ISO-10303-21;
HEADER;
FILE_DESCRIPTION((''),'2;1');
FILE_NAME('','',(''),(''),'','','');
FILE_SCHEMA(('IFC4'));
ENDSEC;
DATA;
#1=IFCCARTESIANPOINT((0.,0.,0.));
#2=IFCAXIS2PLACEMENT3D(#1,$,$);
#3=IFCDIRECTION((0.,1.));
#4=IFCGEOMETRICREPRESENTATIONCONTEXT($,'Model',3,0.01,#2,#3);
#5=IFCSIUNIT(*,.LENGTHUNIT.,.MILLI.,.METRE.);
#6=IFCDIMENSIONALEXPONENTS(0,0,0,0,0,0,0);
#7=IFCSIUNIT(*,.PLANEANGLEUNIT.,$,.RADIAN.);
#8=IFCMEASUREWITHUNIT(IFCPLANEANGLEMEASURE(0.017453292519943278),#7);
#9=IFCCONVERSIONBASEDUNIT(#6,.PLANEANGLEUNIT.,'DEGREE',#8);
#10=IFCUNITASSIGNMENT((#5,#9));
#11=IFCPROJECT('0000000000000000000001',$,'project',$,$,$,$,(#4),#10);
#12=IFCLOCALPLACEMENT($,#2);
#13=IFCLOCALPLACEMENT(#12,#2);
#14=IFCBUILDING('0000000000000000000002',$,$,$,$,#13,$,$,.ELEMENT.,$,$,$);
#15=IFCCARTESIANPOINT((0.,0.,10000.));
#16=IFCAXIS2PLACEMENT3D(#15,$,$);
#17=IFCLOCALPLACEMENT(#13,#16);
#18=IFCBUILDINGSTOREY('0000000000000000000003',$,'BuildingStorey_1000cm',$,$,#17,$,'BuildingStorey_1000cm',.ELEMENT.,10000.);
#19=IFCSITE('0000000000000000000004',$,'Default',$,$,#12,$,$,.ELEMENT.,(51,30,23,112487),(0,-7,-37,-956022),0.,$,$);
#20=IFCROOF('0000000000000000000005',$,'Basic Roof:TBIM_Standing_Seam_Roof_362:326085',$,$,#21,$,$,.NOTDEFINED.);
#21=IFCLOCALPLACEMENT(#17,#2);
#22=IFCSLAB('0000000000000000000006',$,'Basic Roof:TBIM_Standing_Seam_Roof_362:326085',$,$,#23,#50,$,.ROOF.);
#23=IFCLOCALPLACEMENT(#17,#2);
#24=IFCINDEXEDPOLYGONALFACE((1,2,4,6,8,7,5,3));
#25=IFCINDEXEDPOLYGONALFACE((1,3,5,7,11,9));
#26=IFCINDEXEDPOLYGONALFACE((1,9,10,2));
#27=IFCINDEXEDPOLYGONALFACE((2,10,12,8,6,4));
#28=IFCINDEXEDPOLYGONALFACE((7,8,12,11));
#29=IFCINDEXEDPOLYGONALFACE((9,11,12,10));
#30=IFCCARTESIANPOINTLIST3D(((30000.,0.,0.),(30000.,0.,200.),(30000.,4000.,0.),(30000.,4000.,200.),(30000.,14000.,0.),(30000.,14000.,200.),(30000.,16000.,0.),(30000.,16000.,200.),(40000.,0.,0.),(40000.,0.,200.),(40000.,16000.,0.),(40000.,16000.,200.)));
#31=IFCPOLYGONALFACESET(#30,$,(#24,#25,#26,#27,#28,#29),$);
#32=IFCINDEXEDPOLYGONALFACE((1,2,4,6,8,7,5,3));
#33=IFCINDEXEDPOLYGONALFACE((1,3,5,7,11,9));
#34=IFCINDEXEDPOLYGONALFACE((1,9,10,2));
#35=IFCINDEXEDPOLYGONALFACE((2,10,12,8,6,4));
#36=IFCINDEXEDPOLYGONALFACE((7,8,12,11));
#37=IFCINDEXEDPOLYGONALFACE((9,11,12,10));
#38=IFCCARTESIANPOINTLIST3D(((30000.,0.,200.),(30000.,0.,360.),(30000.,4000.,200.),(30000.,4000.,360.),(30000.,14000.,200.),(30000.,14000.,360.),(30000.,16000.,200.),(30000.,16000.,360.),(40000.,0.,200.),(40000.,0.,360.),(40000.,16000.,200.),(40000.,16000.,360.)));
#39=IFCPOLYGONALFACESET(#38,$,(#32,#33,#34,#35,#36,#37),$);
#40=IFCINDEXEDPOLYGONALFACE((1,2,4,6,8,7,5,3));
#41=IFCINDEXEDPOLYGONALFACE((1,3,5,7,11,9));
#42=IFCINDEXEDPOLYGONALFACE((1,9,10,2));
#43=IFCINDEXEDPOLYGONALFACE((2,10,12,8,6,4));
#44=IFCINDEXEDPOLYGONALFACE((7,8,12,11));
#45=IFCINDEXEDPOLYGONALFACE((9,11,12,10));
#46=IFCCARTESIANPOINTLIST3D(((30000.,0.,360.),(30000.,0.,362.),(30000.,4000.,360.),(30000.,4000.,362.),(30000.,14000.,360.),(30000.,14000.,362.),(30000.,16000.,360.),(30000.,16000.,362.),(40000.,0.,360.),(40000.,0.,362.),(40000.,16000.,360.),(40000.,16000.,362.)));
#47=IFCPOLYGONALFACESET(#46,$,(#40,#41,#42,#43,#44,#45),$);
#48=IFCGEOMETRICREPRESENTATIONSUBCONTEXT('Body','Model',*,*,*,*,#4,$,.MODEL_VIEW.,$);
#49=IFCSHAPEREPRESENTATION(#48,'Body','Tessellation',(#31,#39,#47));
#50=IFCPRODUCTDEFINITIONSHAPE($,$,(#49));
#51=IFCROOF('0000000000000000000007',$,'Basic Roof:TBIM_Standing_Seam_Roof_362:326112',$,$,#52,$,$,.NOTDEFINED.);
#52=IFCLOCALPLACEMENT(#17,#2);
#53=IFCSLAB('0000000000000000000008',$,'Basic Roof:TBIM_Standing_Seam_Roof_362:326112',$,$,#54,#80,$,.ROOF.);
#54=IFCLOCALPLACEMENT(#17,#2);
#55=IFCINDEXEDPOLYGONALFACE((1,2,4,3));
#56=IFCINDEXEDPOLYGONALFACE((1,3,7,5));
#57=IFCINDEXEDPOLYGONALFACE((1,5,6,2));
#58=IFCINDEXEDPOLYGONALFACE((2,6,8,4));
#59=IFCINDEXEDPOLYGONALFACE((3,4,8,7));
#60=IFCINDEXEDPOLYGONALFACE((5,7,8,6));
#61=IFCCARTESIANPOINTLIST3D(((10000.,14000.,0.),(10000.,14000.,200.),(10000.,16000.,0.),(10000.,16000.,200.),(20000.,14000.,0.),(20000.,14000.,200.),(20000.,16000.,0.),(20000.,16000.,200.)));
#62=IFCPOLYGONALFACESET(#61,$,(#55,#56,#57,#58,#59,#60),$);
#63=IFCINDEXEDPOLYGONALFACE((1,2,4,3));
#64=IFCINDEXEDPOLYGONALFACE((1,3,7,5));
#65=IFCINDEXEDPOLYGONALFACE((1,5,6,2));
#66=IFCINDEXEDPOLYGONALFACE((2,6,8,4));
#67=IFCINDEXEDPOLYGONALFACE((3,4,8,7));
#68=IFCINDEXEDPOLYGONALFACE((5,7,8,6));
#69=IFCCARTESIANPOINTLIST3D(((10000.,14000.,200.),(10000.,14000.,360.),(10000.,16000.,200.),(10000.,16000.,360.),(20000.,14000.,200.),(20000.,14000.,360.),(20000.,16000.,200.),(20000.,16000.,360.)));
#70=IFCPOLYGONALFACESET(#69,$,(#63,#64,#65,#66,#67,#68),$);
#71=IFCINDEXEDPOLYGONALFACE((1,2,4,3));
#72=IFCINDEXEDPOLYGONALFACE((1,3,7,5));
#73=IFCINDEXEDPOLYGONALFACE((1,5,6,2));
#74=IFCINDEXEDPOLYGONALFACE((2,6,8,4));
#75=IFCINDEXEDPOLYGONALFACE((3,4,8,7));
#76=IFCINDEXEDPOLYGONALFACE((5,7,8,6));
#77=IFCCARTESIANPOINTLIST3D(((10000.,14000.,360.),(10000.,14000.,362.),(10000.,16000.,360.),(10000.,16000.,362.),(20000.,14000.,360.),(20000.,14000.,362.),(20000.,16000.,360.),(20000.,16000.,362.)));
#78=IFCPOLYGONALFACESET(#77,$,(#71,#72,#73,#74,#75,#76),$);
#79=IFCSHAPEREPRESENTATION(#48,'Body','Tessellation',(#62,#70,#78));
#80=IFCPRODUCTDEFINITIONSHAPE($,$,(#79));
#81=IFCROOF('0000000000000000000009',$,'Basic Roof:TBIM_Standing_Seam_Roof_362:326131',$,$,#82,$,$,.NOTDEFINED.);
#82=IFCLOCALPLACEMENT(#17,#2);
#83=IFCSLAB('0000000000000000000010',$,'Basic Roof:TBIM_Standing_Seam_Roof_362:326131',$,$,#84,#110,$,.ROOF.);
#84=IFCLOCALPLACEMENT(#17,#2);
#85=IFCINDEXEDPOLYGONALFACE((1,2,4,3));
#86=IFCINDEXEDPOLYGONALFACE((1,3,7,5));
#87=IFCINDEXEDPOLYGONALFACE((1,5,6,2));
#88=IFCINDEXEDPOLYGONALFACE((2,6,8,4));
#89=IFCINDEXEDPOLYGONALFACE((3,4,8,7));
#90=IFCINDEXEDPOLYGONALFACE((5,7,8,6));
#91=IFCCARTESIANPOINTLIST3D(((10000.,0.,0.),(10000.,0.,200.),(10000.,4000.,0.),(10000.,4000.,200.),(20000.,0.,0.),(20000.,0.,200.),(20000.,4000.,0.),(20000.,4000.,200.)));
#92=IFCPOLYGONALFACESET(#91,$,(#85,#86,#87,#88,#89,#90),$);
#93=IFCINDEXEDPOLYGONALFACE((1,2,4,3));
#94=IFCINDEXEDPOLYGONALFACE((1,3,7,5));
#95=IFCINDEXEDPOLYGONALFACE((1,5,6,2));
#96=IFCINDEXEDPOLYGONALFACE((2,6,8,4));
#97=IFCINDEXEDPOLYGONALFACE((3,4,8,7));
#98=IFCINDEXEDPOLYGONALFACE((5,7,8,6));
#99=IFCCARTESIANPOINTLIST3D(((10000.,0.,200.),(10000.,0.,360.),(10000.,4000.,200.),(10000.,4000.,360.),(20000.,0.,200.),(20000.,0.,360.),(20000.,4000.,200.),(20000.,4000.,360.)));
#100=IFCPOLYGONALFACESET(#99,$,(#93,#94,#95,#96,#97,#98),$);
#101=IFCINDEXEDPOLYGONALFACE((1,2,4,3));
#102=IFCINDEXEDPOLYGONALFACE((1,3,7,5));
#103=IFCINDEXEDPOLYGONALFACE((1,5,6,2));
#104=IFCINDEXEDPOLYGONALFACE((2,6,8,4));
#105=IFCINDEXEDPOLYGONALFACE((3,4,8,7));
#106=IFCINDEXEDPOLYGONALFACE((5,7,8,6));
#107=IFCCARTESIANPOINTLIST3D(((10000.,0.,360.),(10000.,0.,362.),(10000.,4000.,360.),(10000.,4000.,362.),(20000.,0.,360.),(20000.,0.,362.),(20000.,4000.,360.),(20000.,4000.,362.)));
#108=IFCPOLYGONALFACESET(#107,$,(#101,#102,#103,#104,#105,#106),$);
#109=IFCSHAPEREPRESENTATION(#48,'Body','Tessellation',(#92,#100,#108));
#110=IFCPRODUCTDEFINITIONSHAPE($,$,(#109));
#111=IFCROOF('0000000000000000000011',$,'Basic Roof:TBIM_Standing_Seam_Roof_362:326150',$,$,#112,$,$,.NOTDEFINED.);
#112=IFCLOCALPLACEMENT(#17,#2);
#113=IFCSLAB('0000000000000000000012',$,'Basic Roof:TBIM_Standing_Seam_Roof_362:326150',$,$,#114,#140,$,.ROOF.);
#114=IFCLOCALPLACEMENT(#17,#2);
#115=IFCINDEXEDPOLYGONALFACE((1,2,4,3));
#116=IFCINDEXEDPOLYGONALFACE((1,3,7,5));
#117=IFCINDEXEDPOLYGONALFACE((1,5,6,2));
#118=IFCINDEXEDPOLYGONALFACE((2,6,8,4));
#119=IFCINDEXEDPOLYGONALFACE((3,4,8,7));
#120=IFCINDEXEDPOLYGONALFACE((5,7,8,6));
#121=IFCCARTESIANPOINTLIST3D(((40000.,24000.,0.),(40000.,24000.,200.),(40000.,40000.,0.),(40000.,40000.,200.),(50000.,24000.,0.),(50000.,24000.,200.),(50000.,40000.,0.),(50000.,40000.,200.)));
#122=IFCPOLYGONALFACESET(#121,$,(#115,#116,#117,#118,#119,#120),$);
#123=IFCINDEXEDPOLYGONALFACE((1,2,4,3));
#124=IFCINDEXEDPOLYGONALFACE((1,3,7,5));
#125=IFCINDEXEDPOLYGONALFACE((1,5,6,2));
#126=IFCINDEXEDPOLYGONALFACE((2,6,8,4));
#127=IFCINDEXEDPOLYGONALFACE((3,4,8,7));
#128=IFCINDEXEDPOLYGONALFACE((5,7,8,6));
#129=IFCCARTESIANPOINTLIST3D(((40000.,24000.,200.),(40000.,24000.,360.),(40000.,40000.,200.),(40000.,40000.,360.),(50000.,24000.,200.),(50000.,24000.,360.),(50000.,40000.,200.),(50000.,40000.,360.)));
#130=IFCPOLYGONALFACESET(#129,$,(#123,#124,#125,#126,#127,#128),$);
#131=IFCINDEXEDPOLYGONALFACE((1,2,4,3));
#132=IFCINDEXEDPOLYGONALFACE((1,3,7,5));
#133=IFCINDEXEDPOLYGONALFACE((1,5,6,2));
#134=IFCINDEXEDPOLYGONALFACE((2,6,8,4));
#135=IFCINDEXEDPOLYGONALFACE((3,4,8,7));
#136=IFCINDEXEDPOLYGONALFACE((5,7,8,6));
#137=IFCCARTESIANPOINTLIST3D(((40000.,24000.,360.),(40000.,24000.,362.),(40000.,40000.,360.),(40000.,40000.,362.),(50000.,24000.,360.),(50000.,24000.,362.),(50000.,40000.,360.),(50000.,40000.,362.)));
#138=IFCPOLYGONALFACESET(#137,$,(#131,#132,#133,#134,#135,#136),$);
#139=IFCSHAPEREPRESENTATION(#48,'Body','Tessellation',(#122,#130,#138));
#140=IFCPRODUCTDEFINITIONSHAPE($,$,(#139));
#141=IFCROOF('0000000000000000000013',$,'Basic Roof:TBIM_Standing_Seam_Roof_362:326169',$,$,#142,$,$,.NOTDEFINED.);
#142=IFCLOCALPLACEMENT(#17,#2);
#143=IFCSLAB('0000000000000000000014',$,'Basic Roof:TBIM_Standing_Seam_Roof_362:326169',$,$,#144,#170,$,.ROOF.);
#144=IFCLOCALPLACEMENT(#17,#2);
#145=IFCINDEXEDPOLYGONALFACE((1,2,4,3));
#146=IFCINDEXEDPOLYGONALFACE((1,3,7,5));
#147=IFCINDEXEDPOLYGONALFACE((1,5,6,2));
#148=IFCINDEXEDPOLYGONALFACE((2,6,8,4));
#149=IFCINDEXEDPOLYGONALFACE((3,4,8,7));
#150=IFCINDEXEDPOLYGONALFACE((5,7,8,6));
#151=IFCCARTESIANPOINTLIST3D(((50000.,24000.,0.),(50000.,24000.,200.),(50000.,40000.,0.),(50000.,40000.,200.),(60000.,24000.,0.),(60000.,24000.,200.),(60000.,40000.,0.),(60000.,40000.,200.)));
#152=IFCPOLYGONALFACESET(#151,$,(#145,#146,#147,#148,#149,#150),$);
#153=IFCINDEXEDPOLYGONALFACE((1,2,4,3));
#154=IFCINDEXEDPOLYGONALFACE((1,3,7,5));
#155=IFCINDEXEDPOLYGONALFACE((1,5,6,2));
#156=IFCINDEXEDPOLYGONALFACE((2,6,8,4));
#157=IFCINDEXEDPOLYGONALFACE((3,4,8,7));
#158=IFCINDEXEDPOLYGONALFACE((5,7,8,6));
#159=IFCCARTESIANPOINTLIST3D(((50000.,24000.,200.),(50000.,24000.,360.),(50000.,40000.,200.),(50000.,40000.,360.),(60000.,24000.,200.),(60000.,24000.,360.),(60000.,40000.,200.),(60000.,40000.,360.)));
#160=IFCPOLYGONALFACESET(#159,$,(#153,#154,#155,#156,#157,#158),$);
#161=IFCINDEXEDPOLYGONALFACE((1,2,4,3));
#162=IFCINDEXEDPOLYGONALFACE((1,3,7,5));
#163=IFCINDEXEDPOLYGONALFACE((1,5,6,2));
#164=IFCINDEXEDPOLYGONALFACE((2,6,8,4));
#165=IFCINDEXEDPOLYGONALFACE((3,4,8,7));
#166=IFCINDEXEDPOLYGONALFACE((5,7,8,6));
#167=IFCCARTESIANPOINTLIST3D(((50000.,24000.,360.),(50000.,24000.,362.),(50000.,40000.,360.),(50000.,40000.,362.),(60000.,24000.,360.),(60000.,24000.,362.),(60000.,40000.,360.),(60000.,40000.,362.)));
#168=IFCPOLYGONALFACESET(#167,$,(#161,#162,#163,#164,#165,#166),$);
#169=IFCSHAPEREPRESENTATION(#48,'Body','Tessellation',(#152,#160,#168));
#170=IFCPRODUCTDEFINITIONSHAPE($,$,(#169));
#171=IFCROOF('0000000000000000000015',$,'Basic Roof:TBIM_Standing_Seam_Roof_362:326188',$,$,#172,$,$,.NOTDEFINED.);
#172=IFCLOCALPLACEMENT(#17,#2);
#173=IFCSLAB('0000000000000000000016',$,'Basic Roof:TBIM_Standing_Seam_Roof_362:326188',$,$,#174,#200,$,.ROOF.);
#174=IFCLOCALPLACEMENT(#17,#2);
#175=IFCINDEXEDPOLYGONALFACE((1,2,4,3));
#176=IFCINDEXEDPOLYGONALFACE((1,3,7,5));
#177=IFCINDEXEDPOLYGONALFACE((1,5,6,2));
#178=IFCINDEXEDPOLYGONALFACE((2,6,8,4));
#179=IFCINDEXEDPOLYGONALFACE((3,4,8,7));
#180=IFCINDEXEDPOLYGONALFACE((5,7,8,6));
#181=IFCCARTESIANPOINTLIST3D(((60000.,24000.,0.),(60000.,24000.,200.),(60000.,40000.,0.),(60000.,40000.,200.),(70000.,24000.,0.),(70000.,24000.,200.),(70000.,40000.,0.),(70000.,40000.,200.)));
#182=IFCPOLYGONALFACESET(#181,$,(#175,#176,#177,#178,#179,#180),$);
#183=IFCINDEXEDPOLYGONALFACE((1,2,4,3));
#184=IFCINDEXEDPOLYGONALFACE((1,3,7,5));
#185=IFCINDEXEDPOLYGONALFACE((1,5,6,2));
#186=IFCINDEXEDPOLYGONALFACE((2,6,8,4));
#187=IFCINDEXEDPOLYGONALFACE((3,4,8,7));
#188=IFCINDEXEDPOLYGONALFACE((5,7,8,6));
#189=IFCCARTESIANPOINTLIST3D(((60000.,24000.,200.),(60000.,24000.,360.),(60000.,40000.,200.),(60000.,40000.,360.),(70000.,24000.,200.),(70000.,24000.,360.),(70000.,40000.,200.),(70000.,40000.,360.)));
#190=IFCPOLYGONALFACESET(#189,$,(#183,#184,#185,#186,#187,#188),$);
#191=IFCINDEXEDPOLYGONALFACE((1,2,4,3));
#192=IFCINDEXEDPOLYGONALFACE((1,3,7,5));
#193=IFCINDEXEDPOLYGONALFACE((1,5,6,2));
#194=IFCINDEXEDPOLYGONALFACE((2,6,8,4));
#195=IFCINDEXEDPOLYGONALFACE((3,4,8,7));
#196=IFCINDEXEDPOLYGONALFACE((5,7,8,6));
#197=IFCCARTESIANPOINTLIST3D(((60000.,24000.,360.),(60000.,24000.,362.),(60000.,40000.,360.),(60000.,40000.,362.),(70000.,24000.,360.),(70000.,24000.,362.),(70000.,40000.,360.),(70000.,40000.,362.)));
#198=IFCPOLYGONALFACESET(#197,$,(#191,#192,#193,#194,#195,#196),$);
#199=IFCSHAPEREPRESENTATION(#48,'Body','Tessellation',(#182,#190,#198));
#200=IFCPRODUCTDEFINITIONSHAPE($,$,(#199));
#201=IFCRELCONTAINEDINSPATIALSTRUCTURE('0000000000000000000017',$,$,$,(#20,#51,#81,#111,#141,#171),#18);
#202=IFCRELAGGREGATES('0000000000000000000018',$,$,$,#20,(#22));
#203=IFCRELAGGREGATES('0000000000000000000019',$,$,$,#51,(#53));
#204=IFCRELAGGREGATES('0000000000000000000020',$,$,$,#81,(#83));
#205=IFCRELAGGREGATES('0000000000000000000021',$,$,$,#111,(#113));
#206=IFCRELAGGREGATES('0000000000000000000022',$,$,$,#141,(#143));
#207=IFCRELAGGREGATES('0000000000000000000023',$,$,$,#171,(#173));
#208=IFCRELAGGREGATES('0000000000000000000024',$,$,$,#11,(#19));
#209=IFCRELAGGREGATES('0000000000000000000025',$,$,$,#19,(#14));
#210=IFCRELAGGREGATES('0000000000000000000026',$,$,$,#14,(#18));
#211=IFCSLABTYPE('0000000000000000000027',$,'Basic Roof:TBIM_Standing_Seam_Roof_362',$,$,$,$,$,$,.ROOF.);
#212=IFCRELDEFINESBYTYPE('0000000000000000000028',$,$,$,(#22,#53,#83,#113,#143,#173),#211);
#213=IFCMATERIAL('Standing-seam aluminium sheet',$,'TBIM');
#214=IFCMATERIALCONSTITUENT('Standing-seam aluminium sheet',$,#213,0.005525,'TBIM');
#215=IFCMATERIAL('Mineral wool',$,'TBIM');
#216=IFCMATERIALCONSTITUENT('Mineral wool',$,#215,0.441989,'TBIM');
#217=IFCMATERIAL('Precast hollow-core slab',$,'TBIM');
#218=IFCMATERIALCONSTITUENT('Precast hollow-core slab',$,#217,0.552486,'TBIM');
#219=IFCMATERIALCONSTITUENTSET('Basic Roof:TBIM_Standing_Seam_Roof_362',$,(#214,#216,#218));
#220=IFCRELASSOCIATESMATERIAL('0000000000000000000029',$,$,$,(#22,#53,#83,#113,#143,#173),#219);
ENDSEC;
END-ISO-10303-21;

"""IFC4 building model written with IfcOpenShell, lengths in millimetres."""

from ifc_helpers import new_model, entity, si_unit, converted_unit, direction, frame, origin, place, context, subcontext, project, spatial, indexed_curve, outline, extrude, material, constituent, constituent_set, type_object, element, aggregate, save


model = new_model("IFC4")

# Units and contexts
model_context = context("Model", 3, precision=0.01, world=origin(), true_north=direction((0.0, 1.0)))
body_context = subcontext(model_context, "Body", "Model", "MODEL_VIEW")
ifc_project = project(units=[si_unit("LENGTHUNIT", "METRE", prefix="MILLI"), converted_unit("PLANEANGLEUNIT", "DEGREE", entity("IfcPlaneAngleMeasure", 0.017453292519943278), si_unit("PLANEANGLEUNIT", "RADIAN"), dimensions=[0, 0, 0, 0, 0, 0, 0])], contexts=[model_context])

# Site, building, storey
site_placement = place(None, origin())
site = spatial("IfcSite", under=ifc_project, at=site_placement, Name="Default", CompositionType="ELEMENT", RefLatitude=(51, 30, 23, 112487), RefLongitude=(0, -7, -37, -956022), RefElevation=0.0)
building_placement = place(site_placement, origin())
building = spatial("IfcBuilding", under=site, at=building_placement, CompositionType="ELEMENT")
storey_placement = place(building_placement, frame((0.0, 0.0, 10000.0)))
storey = spatial("IfcBuildingStorey", under=building, at=storey_placement, Name="BuildingStorey_1000cm", LongName="BuildingStorey_1000cm", CompositionType="ELEMENT", Elevation=10000.0)

# Shared definitions
ifc_material_1 = material(Name="Precast hollow-core slab", Category="TBIM")

# Roofs, slabs
ifc_material_2 = material(Name="Standing-seam aluminium sheet", Category="TBIM")
ifc_constituent_1 = constituent(ifc_material_2, Name="Standing-seam aluminium sheet", Category="TBIM", fraction=0.005525)
ifc_material_3 = material(Name="Mineral wool", Category="TBIM")
ifc_constituent_2 = constituent(ifc_material_3, Name="Mineral wool", Category="TBIM", fraction=0.441989)
ifc_constituent_3 = constituent(ifc_material_1, Name="Precast hollow-core slab", Category="TBIM", fraction=0.552486)
ifc_constituent_set_1 = constituent_set(constituents=[ifc_constituent_1, ifc_constituent_2, ifc_constituent_3], Name="Basic Roof:TBIM_Standing_Seam_Roof_362")
slab_type_1 = type_object("IfcSlabType", Name="Basic Roof:TBIM_Standing_Seam_Roof_362", PredefinedType="ROOF")
roof_1_placement = place(storey_placement, frame((30000.0, 0.0, 0.0)))
roof_1 = element("IfcRoof", 1, at=roof_1_placement, inside=storey, Name="Basic Roof:TBIM_Standing_Seam_Roof_362:326085", PredefinedType="NOTDEFINED")
slab_1_placement = place(roof_1_placement, origin())
slab_1 = element("IfcSlab", 2, at=slab_1_placement, type_object=slab_type_1, material=ifc_constituent_set_1, Name="Basic Roof:TBIM_Standing_Seam_Roof_362:326085", PredefinedType="ROOF", context=body_context, shape_type="SweptSolid", body=[
    extrude(outline(indexed_curve([(-5000.0, 8000.0), (-5000.0, 6000.0), (-5000.0, -4000.0), (-5000.0, -8000.0), (5000.0, -8000.0), (5000.0, 8000.0), (-5000.0, 8000.0)], self_intersect=False)), frame((5000.0, 8000.0, 0.0)), (0.0, 0.0, 1.0), 200.0),
    extrude(outline(indexed_curve([(-5000.0, 8000.0), (-5000.0, 6000.0), (-5000.0, -4000.0), (-5000.0, -8000.0), (5000.0, -8000.0), (5000.0, 8000.0), (-5000.0, 8000.0)], self_intersect=False)), frame((5000.0, 8000.0, 200.0)), (0.0, 0.0, 1.0), 160.0),
    extrude(outline(indexed_curve([(-5000.0, 8000.0), (-5000.0, 6000.0), (-5000.0, -4000.0), (-5000.0, -8000.0), (5000.0, -8000.0), (5000.0, 8000.0), (-5000.0, 8000.0)], self_intersect=False)), frame((5000.0, 8000.0, 360.0)), (0.0, 0.0, 1.0), 2.0),
])
aggregate(roof_1, [slab_1])
roof_2_placement = place(storey_placement, frame((10000.0, 14000.0, 0.0)))
roof_2 = element("IfcRoof", 3, at=roof_2_placement, inside=storey, Name="Basic Roof:TBIM_Standing_Seam_Roof_362:326112", PredefinedType="NOTDEFINED")
slab_2_placement = place(roof_2_placement, origin())
slab_2 = element("IfcSlab", 4, at=slab_2_placement, type_object=slab_type_1, material=ifc_constituent_set_1, Name="Basic Roof:TBIM_Standing_Seam_Roof_362:326112", PredefinedType="ROOF", context=body_context, shape_type="SweptSolid", body=[
    extrude(outline(indexed_curve([(-5000.0, 1000.0), (-5000.0, -1000.0), (5000.0, -1000.0), (5000.0, 1000.0), (-5000.0, 1000.0)], self_intersect=False)), frame((5000.0, 1000.0, 0.0)), (0.0, 0.0, 1.0), 200.0),
    extrude(outline(indexed_curve([(-5000.0, 1000.0), (-5000.0, -1000.0), (5000.0, -1000.0), (5000.0, 1000.0), (-5000.0, 1000.0)], self_intersect=False)), frame((5000.0, 1000.0, 200.0)), (0.0, 0.0, 1.0), 160.0),
    extrude(outline(indexed_curve([(-5000.0, 1000.0), (-5000.0, -1000.0), (5000.0, -1000.0), (5000.0, 1000.0), (-5000.0, 1000.0)], self_intersect=False)), frame((5000.0, 1000.0, 360.0)), (0.0, 0.0, 1.0), 2.0),
])
aggregate(roof_2, [slab_2])
roof_3_placement = place(storey_placement, frame((10000.0, 0.0, 0.0)))
roof_3 = element("IfcRoof", 5, at=roof_3_placement, inside=storey, Name="Basic Roof:TBIM_Standing_Seam_Roof_362:326131", PredefinedType="NOTDEFINED")
slab_3_placement = place(roof_3_placement, origin())
slab_3 = element("IfcSlab", 6, at=slab_3_placement, type_object=slab_type_1, material=ifc_constituent_set_1, Name="Basic Roof:TBIM_Standing_Seam_Roof_362:326131", PredefinedType="ROOF", context=body_context, shape_type="SweptSolid", body=[
    extrude(outline(indexed_curve([(-5000.0, 2000.0), (-5000.0, -2000.0), (5000.0, -2000.0), (5000.0, 2000.0), (-5000.0, 2000.0)], self_intersect=False)), frame((5000.0, 2000.0, 0.0)), (0.0, 0.0, 1.0), 200.0),
    extrude(outline(indexed_curve([(-5000.0, 2000.0), (-5000.0, -2000.0), (5000.0, -2000.0), (5000.0, 2000.0), (-5000.0, 2000.0)], self_intersect=False)), frame((5000.0, 2000.0, 200.0)), (0.0, 0.0, 1.0), 160.0),
    extrude(outline(indexed_curve([(-5000.0, 2000.0), (-5000.0, -2000.0), (5000.0, -2000.0), (5000.0, 2000.0), (-5000.0, 2000.0)], self_intersect=False)), frame((5000.0, 2000.0, 360.0)), (0.0, 0.0, 1.0), 2.0),
])
aggregate(roof_3, [slab_3])
roof_4_placement = place(storey_placement, frame((40000.0, 24000.0, 0.0)))
roof_4 = element("IfcRoof", 7, at=roof_4_placement, inside=storey, Name="Basic Roof:TBIM_Standing_Seam_Roof_362:326150", PredefinedType="NOTDEFINED")
slab_4_placement = place(roof_4_placement, origin())
slab_4 = element("IfcSlab", 8, at=slab_4_placement, type_object=slab_type_1, material=ifc_constituent_set_1, Name="Basic Roof:TBIM_Standing_Seam_Roof_362:326150", PredefinedType="ROOF", context=body_context, shape_type="SweptSolid", body=[
    extrude(outline(indexed_curve([(-5000.0, 8000.0), (-5000.0, -8000.0), (5000.0, -8000.0), (5000.0, 8000.0), (-5000.0, 8000.0)], self_intersect=False)), frame((5000.0, 8000.0, 0.0)), (0.0, 0.0, 1.0), 200.0),
    extrude(outline(indexed_curve([(-5000.0, 8000.0), (-5000.0, -8000.0), (5000.0, -8000.0), (5000.0, 8000.0), (-5000.0, 8000.0)], self_intersect=False)), frame((5000.0, 8000.0, 200.0)), (0.0, 0.0, 1.0), 160.0),
    extrude(outline(indexed_curve([(-5000.0, 8000.0), (-5000.0, -8000.0), (5000.0, -8000.0), (5000.0, 8000.0), (-5000.0, 8000.0)], self_intersect=False)), frame((5000.0, 8000.0, 360.0)), (0.0, 0.0, 1.0), 2.0),
])
aggregate(roof_4, [slab_4])
roof_5_placement = place(storey_placement, frame((50000.0, 24000.0, 0.0)))
roof_5 = element("IfcRoof", 9, at=roof_5_placement, inside=storey, Name="Basic Roof:TBIM_Standing_Seam_Roof_362:326169", PredefinedType="NOTDEFINED")
slab_5_placement = place(roof_5_placement, origin())
slab_5 = element("IfcSlab", 10, at=slab_5_placement, type_object=slab_type_1, material=ifc_constituent_set_1, Name="Basic Roof:TBIM_Standing_Seam_Roof_362:326169", PredefinedType="ROOF", context=body_context, shape_type="SweptSolid", body=[
    extrude(outline(indexed_curve([(-5000.0, 8000.0), (-5000.0, -8000.0), (5000.0, -8000.0), (5000.0, 8000.0), (-5000.0, 8000.0)], self_intersect=False)), frame((5000.0, 8000.0, 0.0)), (0.0, 0.0, 1.0), 200.0),
    extrude(outline(indexed_curve([(-5000.0, 8000.0), (-5000.0, -8000.0), (5000.0, -8000.0), (5000.0, 8000.0), (-5000.0, 8000.0)], self_intersect=False)), frame((5000.0, 8000.0, 200.0)), (0.0, 0.0, 1.0), 160.0),
    extrude(outline(indexed_curve([(-5000.0, 8000.0), (-5000.0, -8000.0), (5000.0, -8000.0), (5000.0, 8000.0), (-5000.0, 8000.0)], self_intersect=False)), frame((5000.0, 8000.0, 360.0)), (0.0, 0.0, 1.0), 2.0),
])
aggregate(roof_5, [slab_5])
roof_6_placement = place(storey_placement, frame((60000.0, 24000.0, 0.0)))
roof_6 = element("IfcRoof", 11, at=roof_6_placement, inside=storey, Name="Basic Roof:TBIM_Standing_Seam_Roof_362:326188", PredefinedType="NOTDEFINED")
slab_6_placement = place(roof_6_placement, origin())
slab_6 = element("IfcSlab", 12, at=slab_6_placement, type_object=slab_type_1, material=ifc_constituent_set_1, Name="Basic Roof:TBIM_Standing_Seam_Roof_362:326188", PredefinedType="ROOF", context=body_context, shape_type="SweptSolid", body=[
    extrude(outline(indexed_curve([(-5000.0, 8000.0), (-5000.0, -8000.0), (5000.0, -8000.0), (5000.0, 8000.0), (-5000.0, 8000.0)], self_intersect=False)), frame((5000.0, 8000.0, 0.0)), (0.0, 0.0, 1.0), 200.0),
    extrude(outline(indexed_curve([(-5000.0, 8000.0), (-5000.0, -8000.0), (5000.0, -8000.0), (5000.0, 8000.0), (-5000.0, 8000.0)], self_intersect=False)), frame((5000.0, 8000.0, 200.0)), (0.0, 0.0, 1.0), 160.0),
    extrude(outline(indexed_curve([(-5000.0, 8000.0), (-5000.0, -8000.0), (5000.0, -8000.0), (5000.0, 8000.0), (-5000.0, 8000.0)], self_intersect=False)), frame((5000.0, 8000.0, 360.0)), (0.0, 0.0, 1.0), 2.0),
])
aggregate(roof_6, [slab_6])

save(model, "model.ifc")
